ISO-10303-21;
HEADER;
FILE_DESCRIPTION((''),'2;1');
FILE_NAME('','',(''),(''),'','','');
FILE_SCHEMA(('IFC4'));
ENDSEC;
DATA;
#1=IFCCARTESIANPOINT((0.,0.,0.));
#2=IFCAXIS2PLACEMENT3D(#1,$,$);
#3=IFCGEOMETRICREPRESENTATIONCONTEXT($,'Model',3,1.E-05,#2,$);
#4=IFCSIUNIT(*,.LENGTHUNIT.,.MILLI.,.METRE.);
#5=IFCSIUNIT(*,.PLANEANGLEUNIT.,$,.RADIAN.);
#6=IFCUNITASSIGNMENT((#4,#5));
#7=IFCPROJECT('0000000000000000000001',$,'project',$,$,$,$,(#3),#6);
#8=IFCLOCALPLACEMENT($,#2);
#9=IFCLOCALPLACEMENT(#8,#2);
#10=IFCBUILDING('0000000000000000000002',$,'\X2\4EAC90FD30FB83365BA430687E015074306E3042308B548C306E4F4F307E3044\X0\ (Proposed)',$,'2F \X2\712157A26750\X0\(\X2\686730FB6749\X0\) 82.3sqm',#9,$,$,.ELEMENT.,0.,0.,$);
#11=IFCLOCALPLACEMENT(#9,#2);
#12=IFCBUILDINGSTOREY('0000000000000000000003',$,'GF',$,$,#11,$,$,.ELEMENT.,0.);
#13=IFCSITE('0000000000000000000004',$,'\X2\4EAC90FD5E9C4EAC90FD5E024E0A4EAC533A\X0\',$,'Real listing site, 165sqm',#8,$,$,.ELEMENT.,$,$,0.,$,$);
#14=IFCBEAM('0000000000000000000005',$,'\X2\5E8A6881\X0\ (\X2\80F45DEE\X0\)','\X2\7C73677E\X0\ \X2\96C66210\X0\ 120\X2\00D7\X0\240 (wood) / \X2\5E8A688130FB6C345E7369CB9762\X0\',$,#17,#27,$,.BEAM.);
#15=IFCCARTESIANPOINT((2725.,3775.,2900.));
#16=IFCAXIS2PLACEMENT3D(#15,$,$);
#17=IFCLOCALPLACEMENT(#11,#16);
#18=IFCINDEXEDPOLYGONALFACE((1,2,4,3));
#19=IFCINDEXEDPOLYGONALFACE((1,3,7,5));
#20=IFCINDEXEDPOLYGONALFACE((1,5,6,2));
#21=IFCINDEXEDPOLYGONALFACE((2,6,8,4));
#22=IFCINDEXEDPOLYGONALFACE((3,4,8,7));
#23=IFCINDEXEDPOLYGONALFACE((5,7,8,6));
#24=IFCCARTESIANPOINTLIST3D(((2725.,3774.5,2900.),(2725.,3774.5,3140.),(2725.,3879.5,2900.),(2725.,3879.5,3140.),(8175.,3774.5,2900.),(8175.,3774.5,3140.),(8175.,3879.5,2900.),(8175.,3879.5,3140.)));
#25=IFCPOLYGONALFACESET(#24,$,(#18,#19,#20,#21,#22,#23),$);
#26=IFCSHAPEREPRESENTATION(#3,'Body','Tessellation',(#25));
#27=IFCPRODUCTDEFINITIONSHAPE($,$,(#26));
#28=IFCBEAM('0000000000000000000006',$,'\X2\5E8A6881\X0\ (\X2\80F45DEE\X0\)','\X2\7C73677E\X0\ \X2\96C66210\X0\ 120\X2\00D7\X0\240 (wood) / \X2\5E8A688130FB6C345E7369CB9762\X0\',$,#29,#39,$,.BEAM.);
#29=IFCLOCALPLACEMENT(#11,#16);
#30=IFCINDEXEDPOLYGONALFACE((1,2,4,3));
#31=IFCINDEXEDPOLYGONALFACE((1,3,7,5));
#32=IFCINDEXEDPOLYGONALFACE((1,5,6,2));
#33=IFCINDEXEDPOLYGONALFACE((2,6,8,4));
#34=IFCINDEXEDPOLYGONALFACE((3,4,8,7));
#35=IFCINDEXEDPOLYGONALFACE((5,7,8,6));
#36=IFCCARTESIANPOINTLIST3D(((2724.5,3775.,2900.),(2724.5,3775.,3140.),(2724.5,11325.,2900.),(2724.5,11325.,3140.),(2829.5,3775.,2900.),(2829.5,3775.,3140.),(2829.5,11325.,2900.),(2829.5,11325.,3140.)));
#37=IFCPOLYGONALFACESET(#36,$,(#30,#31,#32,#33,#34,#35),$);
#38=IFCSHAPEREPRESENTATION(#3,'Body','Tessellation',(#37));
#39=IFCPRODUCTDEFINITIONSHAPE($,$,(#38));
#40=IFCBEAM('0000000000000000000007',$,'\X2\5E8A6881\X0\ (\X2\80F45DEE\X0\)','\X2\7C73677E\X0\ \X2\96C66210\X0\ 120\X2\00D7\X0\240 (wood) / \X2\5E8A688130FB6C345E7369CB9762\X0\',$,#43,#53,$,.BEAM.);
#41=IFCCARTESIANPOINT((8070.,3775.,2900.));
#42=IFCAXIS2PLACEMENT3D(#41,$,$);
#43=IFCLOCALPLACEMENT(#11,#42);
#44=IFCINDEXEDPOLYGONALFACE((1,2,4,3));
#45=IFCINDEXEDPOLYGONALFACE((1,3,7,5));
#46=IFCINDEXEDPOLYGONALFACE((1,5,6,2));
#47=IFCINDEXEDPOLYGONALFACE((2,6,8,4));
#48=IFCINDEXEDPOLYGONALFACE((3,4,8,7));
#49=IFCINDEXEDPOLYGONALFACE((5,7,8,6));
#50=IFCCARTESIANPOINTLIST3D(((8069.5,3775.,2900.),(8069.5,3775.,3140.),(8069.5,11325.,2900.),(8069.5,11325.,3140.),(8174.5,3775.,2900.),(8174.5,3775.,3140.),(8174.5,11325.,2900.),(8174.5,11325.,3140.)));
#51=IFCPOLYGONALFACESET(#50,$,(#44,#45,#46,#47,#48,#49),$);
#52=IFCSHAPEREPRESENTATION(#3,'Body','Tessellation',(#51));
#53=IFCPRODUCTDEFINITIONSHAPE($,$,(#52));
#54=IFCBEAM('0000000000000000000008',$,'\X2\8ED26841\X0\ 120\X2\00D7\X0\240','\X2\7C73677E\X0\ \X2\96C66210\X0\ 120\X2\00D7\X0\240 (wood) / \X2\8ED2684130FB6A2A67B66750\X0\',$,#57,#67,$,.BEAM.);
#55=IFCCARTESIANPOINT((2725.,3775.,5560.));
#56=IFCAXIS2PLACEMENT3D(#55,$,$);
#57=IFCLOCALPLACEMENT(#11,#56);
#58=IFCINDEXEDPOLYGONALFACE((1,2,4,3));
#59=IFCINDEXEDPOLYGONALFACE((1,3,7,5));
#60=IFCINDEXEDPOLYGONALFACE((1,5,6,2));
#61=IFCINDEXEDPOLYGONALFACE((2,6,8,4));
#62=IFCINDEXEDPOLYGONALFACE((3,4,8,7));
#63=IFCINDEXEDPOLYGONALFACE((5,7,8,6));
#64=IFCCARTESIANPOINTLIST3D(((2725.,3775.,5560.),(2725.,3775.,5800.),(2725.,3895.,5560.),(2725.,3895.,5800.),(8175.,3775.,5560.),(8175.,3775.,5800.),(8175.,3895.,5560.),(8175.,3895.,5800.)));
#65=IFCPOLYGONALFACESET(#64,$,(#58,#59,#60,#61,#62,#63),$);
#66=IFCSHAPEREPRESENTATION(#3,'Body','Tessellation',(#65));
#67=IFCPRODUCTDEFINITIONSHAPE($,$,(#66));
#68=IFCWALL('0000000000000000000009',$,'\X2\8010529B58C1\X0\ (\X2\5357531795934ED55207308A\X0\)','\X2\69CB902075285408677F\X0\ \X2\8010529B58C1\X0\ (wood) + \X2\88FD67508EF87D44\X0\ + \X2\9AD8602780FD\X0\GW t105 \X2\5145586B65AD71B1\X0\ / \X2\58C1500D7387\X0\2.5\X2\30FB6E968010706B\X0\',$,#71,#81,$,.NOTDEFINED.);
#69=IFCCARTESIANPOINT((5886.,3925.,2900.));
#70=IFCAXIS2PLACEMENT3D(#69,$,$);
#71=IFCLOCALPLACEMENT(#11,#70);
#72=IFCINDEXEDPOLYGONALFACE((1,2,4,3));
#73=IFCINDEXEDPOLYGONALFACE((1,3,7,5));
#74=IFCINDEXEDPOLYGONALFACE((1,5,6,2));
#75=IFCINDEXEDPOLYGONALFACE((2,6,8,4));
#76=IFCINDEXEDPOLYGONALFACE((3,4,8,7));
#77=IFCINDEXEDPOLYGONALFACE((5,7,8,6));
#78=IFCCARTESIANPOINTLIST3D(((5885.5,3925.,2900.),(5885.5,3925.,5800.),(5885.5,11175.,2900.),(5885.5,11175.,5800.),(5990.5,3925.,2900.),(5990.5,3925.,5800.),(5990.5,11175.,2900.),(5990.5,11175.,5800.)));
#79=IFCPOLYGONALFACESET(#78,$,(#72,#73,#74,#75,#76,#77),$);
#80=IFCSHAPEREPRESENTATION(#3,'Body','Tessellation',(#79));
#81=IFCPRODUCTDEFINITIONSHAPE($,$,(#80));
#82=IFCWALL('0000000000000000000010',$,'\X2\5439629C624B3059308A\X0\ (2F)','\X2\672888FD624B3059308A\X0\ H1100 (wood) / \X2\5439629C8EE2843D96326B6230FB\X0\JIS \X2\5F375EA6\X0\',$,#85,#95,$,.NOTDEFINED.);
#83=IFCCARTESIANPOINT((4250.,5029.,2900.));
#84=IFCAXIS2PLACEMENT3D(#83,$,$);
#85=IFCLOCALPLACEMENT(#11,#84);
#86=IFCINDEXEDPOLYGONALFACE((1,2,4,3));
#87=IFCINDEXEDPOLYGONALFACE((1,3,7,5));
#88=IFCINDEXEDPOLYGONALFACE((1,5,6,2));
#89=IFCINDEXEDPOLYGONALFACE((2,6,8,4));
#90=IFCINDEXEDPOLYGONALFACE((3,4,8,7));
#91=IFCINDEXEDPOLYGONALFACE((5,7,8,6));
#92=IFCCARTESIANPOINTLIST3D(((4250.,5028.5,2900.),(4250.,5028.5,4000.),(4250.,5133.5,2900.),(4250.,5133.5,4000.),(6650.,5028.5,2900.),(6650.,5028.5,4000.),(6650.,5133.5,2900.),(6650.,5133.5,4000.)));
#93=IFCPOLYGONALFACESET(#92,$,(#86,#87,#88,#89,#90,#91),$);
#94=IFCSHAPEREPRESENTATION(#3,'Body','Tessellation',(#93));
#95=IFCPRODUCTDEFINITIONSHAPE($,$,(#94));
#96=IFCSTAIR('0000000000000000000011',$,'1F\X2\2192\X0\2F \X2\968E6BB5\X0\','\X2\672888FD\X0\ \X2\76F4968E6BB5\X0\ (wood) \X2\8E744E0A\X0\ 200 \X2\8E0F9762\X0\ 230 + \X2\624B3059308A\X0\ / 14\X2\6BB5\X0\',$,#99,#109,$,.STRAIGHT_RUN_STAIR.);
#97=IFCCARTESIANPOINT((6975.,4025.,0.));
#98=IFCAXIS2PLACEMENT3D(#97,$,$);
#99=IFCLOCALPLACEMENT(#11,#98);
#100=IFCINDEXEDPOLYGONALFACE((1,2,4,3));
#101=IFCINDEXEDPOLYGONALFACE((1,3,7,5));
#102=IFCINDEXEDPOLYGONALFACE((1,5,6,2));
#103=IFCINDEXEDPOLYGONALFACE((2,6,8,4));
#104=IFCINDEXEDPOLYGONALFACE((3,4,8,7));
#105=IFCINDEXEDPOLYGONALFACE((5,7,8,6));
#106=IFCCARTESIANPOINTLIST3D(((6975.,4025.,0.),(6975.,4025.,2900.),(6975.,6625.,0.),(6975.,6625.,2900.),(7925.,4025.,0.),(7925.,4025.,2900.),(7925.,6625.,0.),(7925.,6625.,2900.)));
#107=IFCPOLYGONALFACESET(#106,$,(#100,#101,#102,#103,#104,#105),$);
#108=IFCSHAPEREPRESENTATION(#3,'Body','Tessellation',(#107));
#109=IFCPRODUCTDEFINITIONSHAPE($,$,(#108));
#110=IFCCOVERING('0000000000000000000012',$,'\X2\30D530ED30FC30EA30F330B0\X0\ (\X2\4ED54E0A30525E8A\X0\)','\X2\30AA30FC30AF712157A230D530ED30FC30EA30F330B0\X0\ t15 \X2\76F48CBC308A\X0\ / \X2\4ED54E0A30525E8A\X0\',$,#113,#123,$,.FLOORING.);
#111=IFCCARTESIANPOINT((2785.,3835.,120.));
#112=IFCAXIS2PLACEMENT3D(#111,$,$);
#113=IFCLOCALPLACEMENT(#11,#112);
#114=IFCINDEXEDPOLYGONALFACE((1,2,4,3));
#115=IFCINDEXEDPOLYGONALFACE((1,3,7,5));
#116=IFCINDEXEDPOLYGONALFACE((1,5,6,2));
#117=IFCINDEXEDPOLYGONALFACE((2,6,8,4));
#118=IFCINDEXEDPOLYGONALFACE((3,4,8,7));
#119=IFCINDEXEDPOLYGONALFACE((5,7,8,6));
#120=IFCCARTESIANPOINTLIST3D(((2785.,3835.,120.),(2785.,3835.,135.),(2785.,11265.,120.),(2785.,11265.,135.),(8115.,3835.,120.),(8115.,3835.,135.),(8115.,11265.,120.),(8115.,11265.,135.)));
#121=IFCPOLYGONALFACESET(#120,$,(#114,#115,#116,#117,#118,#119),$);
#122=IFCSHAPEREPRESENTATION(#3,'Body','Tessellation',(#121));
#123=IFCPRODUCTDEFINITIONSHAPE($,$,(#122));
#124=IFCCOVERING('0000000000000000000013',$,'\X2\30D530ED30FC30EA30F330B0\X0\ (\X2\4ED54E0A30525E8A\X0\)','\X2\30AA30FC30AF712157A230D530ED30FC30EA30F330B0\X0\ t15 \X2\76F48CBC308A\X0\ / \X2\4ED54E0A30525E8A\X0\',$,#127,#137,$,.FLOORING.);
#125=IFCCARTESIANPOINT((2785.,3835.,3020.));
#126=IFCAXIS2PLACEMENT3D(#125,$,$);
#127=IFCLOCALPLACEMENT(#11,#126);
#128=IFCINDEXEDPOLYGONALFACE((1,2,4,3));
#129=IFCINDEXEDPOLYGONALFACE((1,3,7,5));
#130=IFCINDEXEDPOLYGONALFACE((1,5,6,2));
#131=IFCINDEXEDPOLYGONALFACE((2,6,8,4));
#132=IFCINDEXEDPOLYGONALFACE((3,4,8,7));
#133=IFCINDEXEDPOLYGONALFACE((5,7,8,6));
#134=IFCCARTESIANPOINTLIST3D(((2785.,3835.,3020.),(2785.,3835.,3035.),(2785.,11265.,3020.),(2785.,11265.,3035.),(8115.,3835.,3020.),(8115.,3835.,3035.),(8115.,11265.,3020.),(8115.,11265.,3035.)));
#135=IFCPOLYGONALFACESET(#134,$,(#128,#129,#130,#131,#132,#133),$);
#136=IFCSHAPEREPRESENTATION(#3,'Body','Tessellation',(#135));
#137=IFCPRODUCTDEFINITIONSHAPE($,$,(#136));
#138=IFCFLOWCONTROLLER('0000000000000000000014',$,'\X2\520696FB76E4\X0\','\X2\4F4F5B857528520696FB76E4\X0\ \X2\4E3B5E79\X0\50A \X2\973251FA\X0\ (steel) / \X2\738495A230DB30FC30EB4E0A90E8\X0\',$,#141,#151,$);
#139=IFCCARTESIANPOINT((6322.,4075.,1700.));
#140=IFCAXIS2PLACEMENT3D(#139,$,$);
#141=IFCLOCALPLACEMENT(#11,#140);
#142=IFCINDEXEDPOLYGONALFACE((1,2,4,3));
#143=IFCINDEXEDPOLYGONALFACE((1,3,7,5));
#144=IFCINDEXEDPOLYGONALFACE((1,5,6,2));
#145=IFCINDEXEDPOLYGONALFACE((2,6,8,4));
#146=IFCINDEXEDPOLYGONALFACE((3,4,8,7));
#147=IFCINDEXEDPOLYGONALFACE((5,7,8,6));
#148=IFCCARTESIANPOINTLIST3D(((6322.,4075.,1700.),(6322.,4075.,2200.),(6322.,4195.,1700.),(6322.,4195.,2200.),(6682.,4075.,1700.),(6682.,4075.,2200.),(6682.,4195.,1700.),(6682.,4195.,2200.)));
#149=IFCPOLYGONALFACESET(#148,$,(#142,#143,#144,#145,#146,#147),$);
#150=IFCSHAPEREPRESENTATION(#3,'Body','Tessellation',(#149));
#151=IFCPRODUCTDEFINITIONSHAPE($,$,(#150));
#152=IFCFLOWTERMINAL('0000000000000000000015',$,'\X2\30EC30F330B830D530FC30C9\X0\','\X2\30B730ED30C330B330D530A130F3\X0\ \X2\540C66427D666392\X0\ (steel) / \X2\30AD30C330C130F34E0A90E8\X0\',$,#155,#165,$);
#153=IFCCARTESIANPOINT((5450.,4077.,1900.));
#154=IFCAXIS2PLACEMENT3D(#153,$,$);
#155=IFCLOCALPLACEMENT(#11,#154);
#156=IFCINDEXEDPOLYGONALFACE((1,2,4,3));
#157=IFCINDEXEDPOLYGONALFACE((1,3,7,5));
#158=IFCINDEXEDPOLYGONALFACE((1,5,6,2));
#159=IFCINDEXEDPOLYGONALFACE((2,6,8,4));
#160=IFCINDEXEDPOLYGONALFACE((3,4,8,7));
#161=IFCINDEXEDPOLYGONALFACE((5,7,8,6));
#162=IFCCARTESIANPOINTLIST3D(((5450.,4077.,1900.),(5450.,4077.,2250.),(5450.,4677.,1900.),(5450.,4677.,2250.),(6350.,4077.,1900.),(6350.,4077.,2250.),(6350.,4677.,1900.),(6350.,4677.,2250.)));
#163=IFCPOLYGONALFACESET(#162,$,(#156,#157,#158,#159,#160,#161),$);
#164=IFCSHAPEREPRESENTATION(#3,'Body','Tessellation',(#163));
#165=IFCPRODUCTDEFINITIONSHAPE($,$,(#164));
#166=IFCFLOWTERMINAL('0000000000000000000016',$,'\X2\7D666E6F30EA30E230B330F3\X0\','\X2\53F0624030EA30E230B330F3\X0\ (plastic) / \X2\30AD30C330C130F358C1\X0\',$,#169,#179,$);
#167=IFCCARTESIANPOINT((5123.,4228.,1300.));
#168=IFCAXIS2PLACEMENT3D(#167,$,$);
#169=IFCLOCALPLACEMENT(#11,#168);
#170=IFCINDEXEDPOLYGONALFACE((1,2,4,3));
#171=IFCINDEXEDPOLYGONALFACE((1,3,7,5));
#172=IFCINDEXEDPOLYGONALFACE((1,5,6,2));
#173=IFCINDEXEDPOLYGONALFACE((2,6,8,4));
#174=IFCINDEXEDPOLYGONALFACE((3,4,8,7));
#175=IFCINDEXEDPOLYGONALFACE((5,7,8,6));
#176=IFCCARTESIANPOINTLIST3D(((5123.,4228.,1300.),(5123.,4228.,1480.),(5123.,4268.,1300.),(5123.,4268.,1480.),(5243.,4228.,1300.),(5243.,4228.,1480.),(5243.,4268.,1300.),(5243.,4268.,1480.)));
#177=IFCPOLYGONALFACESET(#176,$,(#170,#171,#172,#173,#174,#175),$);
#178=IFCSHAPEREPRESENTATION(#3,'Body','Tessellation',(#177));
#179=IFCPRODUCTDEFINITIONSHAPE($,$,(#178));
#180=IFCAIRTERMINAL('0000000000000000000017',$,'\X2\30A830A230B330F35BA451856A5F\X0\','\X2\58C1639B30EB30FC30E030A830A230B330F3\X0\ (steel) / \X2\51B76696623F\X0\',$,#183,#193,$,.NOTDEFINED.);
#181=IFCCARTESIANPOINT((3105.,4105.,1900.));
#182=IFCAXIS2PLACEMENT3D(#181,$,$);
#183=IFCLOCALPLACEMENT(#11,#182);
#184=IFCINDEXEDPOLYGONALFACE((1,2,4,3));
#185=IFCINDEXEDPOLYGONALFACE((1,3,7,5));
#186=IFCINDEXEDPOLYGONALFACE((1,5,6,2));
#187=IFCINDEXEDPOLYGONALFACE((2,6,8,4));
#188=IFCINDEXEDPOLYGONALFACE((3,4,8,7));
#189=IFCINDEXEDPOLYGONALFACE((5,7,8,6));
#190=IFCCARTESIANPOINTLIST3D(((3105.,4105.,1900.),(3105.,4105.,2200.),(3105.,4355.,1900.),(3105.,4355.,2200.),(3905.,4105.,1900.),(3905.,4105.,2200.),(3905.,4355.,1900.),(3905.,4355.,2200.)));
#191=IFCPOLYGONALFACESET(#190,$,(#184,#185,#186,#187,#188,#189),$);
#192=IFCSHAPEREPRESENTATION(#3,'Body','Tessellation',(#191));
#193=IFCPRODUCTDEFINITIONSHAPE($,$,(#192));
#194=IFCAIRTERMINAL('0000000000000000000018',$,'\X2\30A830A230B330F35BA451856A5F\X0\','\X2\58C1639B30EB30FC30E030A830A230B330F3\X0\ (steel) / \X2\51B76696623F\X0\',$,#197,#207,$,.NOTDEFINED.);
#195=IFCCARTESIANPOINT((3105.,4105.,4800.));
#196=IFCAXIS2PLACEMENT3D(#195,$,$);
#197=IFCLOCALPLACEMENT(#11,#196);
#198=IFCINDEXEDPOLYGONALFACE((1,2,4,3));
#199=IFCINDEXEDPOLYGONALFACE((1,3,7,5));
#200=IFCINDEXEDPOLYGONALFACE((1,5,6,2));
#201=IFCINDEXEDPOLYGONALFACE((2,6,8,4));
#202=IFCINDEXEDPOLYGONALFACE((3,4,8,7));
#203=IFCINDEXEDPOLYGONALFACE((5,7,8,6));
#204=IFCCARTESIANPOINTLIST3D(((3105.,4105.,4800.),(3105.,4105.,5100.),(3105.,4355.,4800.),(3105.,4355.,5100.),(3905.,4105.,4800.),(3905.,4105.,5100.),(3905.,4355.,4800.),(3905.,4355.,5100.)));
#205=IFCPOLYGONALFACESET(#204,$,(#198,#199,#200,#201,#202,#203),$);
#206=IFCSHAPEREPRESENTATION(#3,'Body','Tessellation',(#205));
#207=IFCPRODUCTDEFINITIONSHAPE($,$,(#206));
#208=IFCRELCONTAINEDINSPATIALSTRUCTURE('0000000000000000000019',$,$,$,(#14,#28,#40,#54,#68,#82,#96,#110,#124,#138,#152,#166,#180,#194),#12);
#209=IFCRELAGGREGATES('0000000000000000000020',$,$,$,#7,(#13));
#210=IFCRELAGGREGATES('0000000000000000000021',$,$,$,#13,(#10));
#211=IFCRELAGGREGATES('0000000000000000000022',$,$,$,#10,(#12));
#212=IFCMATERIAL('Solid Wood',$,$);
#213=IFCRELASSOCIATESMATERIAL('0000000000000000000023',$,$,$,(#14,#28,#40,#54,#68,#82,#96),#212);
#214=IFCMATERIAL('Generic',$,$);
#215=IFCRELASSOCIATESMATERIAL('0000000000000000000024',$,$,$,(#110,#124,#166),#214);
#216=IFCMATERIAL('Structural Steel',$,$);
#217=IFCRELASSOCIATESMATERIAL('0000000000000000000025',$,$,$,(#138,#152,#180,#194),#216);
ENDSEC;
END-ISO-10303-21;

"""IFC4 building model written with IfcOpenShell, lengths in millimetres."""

from ifc_helpers import new_model, si_unit, frame, frame_2d, origin, place, context, project, spatial, rectangle, extrude, material, element, save


model = new_model("IFC4")

# Units and contexts
model_context = context("Model", 3, precision=1e-05, world=origin())
ifc_project = project(units=[si_unit("LENGTHUNIT", "METRE", prefix="MILLI"), si_unit("PLANEANGLEUNIT", "RADIAN")], contexts=[model_context])

# Site, building, storey
site_placement = place(None, origin())
site = spatial("IfcSite", under=ifc_project, at=site_placement, Name="京都府京都市上京区", ObjectType="Real listing site, 165sqm", CompositionType="ELEMENT", RefElevation=0.0)
building_placement = place(site_placement, origin())
building = spatial("IfcBuilding", under=site, at=building_placement, Name="京都・茶室と縁側のある和の住まい (Proposed)", ObjectType="2F 無垢材(桧・杉) 82.3sqm", CompositionType="ELEMENT", ElevationOfRefHeight=0.0, ElevationOfTerrain=0.0)
storey_placement = place(building_placement, origin())
storey = spatial("IfcBuildingStorey", under=building, at=storey_placement, Name="GF", CompositionType="ELEMENT", Elevation=0.0)

# Shared definitions
ifc_material_1 = material(Name="Solid Wood")

# Beams
beam_1_placement = place(storey_placement, frame((2725.0, 3775.0, 2900.0)))
element("IfcBeam", 1, at=beam_1_placement, inside=storey, material=ifc_material_1, Name="床梁 (胴差)", Description="米松 集成 120×240 (wood) / 床梁・水平構面", PredefinedType="BEAM", context=model_context, shape_type="SweptSolid", body=[
    extrude(rectangle(XDim=5450.0, YDim=105.0, at=frame_2d((2725.0, 52.0))), frame((2725.0, 3775.0, 2900.0)), (0.0, 0.0, 1.0), 240.0),
])
beam_2_placement = place(storey_placement, frame((2725.0, 3775.0, 2900.0)))
element("IfcBeam", 2, at=beam_2_placement, inside=storey, material=ifc_material_1, Name="床梁 (胴差)", Description="米松 集成 120×240 (wood) / 床梁・水平構面", PredefinedType="BEAM", context=model_context, shape_type="SweptSolid", body=[
    extrude(rectangle(XDim=105.0, YDim=7550.0, at=frame_2d((52.0, 3775.0))), frame((2725.0, 3775.0, 2900.0)), (0.0, 0.0, 1.0), 240.0),
])
beam_3_placement = place(storey_placement, frame((8070.0, 3775.0, 2900.0)))
element("IfcBeam", 3, at=beam_3_placement, inside=storey, material=ifc_material_1, Name="床梁 (胴差)", Description="米松 集成 120×240 (wood) / 床梁・水平構面", PredefinedType="BEAM", context=model_context, shape_type="SweptSolid", body=[
    extrude(rectangle(XDim=105.0, YDim=7550.0, at=frame_2d((52.0, 3775.0))), frame((8070.0, 3775.0, 2900.0)), (0.0, 0.0, 1.0), 240.0),
])
beam_4_placement = place(storey_placement, frame((2725.0, 3775.0, 5560.0)))
element("IfcBeam", 4, at=beam_4_placement, inside=storey, material=ifc_material_1, Name="軒桁 120×240", Description="米松 集成 120×240 (wood) / 軒桁・横架材", PredefinedType="BEAM", context=model_context, shape_type="SweptSolid", body=[
    extrude(rectangle(XDim=5450.0, YDim=120.0, at=frame_2d((2725.0, 60.0))), frame((2725.0, 3775.0, 5560.0)), (0.0, 0.0, 1.0), 240.0),
])

# Walls
wall_1_placement = place(storey_placement, frame((5886.0, 3925.0, 2900.0)))
element("IfcWall", 5, at=wall_1_placement, inside=storey, material=ifc_material_1, Name="耐力壁 (南北間仕切り)", Description="構造用合板 耐力壁 (wood) + 製材軸組 + 高性能GW t105 充填断熱 / 壁倍率2.5・準耐火", PredefinedType="NOTDEFINED", context=model_context, shape_type="SweptSolid", body=[
    extrude(rectangle(XDim=105.0, YDim=7250.0, at=frame_2d((52.0, 3625.0))), frame((5886.0, 3925.0, 2900.0)), (0.0, 0.0, 1.0), 2900.0),
])
wall_2_placement = place(storey_placement, frame((4250.0, 5029.0, 2900.0)))
element("IfcWall", 6, at=wall_2_placement, inside=storey, material=ifc_material_1, Name="吹抜手すり (2F)", Description="木製手すり H1100 (wood) / 吹抜転落防止・JIS 強度", PredefinedType="NOTDEFINED", context=model_context, shape_type="SweptSolid", body=[
    extrude(rectangle(XDim=2400.0, YDim=105.0, at=frame_2d((1200.0, 52.0))), frame((4250.0, 5029.0, 2900.0)), (0.0, 0.0, 1.0), 1100.0),
])

# Stair
stair_placement = place(storey_placement, frame((6975.0, 4025.0, 0.0)))
element("IfcStair", 7, at=stair_placement, inside=storey, material=ifc_material_1, Name="1F→2F 階段", Description="木製 直階段 (wood) 蹴上 200 踏面 230 + 手すり / 14段", PredefinedType="STRAIGHT_RUN_STAIR", context=model_context, shape_type="SweptSolid", body=[
    extrude(rectangle(XDim=950.0, YDim=2600.0, at=frame_2d((475.0, 1300.0))), frame((6975.0, 4025.0, 0.0)), (0.0, 0.0, 1.0), 2900.0),
])

# Coverings
ifc_material_2 = material(Name="Generic")
covering_1_placement = place(storey_placement, frame((2785.0, 3835.0, 120.0)))
element("IfcCovering", 8, at=covering_1_placement, inside=storey, material=ifc_material_2, Name="フローリング (仕上げ床)", Description="オーク無垢フローリング t15 直貼り / 仕上げ床", PredefinedType="FLOORING", context=model_context, shape_type="SweptSolid", body=[
    extrude(rectangle(XDim=5330.0, YDim=7430.0, at=frame_2d((2665.0, 3715.0))), frame((2785.0, 3835.0, 120.0)), (0.0, 0.0, 1.0), 15.0),
])
covering_2_placement = place(storey_placement, frame((2785.0, 3835.0, 3020.0)))
element("IfcCovering", 9, at=covering_2_placement, inside=storey, material=ifc_material_2, Name="フローリング (仕上げ床)", Description="オーク無垢フローリング t15 直貼り / 仕上げ床", PredefinedType="FLOORING", context=model_context, shape_type="SweptSolid", body=[
    extrude(rectangle(XDim=5330.0, YDim=7430.0, at=frame_2d((2665.0, 3715.0))), frame((2785.0, 3835.0, 3020.0)), (0.0, 0.0, 1.0), 15.0),
])

# Flow controller
ifc_material_3 = material(Name="Structural Steel")
flow_controller_placement = place(storey_placement, frame((6322.0, 4075.0, 1700.0)))
element("IfcFlowController", 10, at=flow_controller_placement, inside=storey, material=ifc_material_3, Name="分電盤", Description="住宅用分電盤 主幹50A 露出 (steel) / 玄関ホール上部", context=model_context, shape_type="SweptSolid", body=[
    extrude(rectangle(XDim=360.0, YDim=120.0, at=frame_2d((180.0, 60.0))), frame((6322.0, 4075.0, 1700.0)), (0.0, 0.0, 1.0), 500.0),
])

# Flow terminals
flow_terminal_1_placement = place(storey_placement, frame((5450.0, 4077.0, 1900.0)))
element("IfcFlowTerminal", 11, at=flow_terminal_1_placement, inside=storey, material=ifc_material_3, Name="レンジフード", Description="シロッコファン 同時給排 (steel) / キッチン上部", context=model_context, shape_type="SweptSolid", body=[
    extrude(rectangle(XDim=900.0, YDim=600.0, at=frame_2d((450.0, 300.0))), frame((5450.0, 4077.0, 1900.0)), (0.0, 0.0, 1.0), 350.0),
])
flow_terminal_2_placement = place(storey_placement, frame((5123.0, 4228.0, 1300.0)))
element("IfcFlowTerminal", 12, at=flow_terminal_2_placement, inside=storey, material=ifc_material_2, Name="給湯リモコン", Description="台所リモコン (plastic) / キッチン壁", context=model_context, shape_type="SweptSolid", body=[
    extrude(rectangle(XDim=120.0, YDim=40.0, at=frame_2d((60.0, 20.0))), frame((5123.0, 4228.0, 1300.0)), (0.0, 0.0, 1.0), 180.0),
])

# Air terminals
air_terminal_1_placement = place(storey_placement, frame((3105.0, 4105.0, 1900.0)))
element("IfcAirTerminal", 13, at=air_terminal_1_placement, inside=storey, material=ifc_material_3, Name="エアコン室内機", Description="壁掛ルームエアコン (steel) / 冷暖房", PredefinedType="NOTDEFINED", context=model_context, shape_type="SweptSolid", body=[
    extrude(rectangle(XDim=800.0, YDim=250.0, at=frame_2d((400.0, 125.0))), frame((3105.0, 4105.0, 1900.0)), (0.0, 0.0, 1.0), 300.0),
])
air_terminal_2_placement = place(storey_placement, frame((3105.0, 4105.0, 4800.0)))
element("IfcAirTerminal", 14, at=air_terminal_2_placement, inside=storey, material=ifc_material_3, Name="エアコン室内機", Description="壁掛ルームエアコン (steel) / 冷暖房", PredefinedType="NOTDEFINED", context=model_context, shape_type="SweptSolid", body=[
    extrude(rectangle(XDim=800.0, YDim=250.0, at=frame_2d((400.0, 125.0))), frame((3105.0, 4105.0, 4800.0)), (0.0, 0.0, 1.0), 300.0),
])

save(model, "model.ifc")
